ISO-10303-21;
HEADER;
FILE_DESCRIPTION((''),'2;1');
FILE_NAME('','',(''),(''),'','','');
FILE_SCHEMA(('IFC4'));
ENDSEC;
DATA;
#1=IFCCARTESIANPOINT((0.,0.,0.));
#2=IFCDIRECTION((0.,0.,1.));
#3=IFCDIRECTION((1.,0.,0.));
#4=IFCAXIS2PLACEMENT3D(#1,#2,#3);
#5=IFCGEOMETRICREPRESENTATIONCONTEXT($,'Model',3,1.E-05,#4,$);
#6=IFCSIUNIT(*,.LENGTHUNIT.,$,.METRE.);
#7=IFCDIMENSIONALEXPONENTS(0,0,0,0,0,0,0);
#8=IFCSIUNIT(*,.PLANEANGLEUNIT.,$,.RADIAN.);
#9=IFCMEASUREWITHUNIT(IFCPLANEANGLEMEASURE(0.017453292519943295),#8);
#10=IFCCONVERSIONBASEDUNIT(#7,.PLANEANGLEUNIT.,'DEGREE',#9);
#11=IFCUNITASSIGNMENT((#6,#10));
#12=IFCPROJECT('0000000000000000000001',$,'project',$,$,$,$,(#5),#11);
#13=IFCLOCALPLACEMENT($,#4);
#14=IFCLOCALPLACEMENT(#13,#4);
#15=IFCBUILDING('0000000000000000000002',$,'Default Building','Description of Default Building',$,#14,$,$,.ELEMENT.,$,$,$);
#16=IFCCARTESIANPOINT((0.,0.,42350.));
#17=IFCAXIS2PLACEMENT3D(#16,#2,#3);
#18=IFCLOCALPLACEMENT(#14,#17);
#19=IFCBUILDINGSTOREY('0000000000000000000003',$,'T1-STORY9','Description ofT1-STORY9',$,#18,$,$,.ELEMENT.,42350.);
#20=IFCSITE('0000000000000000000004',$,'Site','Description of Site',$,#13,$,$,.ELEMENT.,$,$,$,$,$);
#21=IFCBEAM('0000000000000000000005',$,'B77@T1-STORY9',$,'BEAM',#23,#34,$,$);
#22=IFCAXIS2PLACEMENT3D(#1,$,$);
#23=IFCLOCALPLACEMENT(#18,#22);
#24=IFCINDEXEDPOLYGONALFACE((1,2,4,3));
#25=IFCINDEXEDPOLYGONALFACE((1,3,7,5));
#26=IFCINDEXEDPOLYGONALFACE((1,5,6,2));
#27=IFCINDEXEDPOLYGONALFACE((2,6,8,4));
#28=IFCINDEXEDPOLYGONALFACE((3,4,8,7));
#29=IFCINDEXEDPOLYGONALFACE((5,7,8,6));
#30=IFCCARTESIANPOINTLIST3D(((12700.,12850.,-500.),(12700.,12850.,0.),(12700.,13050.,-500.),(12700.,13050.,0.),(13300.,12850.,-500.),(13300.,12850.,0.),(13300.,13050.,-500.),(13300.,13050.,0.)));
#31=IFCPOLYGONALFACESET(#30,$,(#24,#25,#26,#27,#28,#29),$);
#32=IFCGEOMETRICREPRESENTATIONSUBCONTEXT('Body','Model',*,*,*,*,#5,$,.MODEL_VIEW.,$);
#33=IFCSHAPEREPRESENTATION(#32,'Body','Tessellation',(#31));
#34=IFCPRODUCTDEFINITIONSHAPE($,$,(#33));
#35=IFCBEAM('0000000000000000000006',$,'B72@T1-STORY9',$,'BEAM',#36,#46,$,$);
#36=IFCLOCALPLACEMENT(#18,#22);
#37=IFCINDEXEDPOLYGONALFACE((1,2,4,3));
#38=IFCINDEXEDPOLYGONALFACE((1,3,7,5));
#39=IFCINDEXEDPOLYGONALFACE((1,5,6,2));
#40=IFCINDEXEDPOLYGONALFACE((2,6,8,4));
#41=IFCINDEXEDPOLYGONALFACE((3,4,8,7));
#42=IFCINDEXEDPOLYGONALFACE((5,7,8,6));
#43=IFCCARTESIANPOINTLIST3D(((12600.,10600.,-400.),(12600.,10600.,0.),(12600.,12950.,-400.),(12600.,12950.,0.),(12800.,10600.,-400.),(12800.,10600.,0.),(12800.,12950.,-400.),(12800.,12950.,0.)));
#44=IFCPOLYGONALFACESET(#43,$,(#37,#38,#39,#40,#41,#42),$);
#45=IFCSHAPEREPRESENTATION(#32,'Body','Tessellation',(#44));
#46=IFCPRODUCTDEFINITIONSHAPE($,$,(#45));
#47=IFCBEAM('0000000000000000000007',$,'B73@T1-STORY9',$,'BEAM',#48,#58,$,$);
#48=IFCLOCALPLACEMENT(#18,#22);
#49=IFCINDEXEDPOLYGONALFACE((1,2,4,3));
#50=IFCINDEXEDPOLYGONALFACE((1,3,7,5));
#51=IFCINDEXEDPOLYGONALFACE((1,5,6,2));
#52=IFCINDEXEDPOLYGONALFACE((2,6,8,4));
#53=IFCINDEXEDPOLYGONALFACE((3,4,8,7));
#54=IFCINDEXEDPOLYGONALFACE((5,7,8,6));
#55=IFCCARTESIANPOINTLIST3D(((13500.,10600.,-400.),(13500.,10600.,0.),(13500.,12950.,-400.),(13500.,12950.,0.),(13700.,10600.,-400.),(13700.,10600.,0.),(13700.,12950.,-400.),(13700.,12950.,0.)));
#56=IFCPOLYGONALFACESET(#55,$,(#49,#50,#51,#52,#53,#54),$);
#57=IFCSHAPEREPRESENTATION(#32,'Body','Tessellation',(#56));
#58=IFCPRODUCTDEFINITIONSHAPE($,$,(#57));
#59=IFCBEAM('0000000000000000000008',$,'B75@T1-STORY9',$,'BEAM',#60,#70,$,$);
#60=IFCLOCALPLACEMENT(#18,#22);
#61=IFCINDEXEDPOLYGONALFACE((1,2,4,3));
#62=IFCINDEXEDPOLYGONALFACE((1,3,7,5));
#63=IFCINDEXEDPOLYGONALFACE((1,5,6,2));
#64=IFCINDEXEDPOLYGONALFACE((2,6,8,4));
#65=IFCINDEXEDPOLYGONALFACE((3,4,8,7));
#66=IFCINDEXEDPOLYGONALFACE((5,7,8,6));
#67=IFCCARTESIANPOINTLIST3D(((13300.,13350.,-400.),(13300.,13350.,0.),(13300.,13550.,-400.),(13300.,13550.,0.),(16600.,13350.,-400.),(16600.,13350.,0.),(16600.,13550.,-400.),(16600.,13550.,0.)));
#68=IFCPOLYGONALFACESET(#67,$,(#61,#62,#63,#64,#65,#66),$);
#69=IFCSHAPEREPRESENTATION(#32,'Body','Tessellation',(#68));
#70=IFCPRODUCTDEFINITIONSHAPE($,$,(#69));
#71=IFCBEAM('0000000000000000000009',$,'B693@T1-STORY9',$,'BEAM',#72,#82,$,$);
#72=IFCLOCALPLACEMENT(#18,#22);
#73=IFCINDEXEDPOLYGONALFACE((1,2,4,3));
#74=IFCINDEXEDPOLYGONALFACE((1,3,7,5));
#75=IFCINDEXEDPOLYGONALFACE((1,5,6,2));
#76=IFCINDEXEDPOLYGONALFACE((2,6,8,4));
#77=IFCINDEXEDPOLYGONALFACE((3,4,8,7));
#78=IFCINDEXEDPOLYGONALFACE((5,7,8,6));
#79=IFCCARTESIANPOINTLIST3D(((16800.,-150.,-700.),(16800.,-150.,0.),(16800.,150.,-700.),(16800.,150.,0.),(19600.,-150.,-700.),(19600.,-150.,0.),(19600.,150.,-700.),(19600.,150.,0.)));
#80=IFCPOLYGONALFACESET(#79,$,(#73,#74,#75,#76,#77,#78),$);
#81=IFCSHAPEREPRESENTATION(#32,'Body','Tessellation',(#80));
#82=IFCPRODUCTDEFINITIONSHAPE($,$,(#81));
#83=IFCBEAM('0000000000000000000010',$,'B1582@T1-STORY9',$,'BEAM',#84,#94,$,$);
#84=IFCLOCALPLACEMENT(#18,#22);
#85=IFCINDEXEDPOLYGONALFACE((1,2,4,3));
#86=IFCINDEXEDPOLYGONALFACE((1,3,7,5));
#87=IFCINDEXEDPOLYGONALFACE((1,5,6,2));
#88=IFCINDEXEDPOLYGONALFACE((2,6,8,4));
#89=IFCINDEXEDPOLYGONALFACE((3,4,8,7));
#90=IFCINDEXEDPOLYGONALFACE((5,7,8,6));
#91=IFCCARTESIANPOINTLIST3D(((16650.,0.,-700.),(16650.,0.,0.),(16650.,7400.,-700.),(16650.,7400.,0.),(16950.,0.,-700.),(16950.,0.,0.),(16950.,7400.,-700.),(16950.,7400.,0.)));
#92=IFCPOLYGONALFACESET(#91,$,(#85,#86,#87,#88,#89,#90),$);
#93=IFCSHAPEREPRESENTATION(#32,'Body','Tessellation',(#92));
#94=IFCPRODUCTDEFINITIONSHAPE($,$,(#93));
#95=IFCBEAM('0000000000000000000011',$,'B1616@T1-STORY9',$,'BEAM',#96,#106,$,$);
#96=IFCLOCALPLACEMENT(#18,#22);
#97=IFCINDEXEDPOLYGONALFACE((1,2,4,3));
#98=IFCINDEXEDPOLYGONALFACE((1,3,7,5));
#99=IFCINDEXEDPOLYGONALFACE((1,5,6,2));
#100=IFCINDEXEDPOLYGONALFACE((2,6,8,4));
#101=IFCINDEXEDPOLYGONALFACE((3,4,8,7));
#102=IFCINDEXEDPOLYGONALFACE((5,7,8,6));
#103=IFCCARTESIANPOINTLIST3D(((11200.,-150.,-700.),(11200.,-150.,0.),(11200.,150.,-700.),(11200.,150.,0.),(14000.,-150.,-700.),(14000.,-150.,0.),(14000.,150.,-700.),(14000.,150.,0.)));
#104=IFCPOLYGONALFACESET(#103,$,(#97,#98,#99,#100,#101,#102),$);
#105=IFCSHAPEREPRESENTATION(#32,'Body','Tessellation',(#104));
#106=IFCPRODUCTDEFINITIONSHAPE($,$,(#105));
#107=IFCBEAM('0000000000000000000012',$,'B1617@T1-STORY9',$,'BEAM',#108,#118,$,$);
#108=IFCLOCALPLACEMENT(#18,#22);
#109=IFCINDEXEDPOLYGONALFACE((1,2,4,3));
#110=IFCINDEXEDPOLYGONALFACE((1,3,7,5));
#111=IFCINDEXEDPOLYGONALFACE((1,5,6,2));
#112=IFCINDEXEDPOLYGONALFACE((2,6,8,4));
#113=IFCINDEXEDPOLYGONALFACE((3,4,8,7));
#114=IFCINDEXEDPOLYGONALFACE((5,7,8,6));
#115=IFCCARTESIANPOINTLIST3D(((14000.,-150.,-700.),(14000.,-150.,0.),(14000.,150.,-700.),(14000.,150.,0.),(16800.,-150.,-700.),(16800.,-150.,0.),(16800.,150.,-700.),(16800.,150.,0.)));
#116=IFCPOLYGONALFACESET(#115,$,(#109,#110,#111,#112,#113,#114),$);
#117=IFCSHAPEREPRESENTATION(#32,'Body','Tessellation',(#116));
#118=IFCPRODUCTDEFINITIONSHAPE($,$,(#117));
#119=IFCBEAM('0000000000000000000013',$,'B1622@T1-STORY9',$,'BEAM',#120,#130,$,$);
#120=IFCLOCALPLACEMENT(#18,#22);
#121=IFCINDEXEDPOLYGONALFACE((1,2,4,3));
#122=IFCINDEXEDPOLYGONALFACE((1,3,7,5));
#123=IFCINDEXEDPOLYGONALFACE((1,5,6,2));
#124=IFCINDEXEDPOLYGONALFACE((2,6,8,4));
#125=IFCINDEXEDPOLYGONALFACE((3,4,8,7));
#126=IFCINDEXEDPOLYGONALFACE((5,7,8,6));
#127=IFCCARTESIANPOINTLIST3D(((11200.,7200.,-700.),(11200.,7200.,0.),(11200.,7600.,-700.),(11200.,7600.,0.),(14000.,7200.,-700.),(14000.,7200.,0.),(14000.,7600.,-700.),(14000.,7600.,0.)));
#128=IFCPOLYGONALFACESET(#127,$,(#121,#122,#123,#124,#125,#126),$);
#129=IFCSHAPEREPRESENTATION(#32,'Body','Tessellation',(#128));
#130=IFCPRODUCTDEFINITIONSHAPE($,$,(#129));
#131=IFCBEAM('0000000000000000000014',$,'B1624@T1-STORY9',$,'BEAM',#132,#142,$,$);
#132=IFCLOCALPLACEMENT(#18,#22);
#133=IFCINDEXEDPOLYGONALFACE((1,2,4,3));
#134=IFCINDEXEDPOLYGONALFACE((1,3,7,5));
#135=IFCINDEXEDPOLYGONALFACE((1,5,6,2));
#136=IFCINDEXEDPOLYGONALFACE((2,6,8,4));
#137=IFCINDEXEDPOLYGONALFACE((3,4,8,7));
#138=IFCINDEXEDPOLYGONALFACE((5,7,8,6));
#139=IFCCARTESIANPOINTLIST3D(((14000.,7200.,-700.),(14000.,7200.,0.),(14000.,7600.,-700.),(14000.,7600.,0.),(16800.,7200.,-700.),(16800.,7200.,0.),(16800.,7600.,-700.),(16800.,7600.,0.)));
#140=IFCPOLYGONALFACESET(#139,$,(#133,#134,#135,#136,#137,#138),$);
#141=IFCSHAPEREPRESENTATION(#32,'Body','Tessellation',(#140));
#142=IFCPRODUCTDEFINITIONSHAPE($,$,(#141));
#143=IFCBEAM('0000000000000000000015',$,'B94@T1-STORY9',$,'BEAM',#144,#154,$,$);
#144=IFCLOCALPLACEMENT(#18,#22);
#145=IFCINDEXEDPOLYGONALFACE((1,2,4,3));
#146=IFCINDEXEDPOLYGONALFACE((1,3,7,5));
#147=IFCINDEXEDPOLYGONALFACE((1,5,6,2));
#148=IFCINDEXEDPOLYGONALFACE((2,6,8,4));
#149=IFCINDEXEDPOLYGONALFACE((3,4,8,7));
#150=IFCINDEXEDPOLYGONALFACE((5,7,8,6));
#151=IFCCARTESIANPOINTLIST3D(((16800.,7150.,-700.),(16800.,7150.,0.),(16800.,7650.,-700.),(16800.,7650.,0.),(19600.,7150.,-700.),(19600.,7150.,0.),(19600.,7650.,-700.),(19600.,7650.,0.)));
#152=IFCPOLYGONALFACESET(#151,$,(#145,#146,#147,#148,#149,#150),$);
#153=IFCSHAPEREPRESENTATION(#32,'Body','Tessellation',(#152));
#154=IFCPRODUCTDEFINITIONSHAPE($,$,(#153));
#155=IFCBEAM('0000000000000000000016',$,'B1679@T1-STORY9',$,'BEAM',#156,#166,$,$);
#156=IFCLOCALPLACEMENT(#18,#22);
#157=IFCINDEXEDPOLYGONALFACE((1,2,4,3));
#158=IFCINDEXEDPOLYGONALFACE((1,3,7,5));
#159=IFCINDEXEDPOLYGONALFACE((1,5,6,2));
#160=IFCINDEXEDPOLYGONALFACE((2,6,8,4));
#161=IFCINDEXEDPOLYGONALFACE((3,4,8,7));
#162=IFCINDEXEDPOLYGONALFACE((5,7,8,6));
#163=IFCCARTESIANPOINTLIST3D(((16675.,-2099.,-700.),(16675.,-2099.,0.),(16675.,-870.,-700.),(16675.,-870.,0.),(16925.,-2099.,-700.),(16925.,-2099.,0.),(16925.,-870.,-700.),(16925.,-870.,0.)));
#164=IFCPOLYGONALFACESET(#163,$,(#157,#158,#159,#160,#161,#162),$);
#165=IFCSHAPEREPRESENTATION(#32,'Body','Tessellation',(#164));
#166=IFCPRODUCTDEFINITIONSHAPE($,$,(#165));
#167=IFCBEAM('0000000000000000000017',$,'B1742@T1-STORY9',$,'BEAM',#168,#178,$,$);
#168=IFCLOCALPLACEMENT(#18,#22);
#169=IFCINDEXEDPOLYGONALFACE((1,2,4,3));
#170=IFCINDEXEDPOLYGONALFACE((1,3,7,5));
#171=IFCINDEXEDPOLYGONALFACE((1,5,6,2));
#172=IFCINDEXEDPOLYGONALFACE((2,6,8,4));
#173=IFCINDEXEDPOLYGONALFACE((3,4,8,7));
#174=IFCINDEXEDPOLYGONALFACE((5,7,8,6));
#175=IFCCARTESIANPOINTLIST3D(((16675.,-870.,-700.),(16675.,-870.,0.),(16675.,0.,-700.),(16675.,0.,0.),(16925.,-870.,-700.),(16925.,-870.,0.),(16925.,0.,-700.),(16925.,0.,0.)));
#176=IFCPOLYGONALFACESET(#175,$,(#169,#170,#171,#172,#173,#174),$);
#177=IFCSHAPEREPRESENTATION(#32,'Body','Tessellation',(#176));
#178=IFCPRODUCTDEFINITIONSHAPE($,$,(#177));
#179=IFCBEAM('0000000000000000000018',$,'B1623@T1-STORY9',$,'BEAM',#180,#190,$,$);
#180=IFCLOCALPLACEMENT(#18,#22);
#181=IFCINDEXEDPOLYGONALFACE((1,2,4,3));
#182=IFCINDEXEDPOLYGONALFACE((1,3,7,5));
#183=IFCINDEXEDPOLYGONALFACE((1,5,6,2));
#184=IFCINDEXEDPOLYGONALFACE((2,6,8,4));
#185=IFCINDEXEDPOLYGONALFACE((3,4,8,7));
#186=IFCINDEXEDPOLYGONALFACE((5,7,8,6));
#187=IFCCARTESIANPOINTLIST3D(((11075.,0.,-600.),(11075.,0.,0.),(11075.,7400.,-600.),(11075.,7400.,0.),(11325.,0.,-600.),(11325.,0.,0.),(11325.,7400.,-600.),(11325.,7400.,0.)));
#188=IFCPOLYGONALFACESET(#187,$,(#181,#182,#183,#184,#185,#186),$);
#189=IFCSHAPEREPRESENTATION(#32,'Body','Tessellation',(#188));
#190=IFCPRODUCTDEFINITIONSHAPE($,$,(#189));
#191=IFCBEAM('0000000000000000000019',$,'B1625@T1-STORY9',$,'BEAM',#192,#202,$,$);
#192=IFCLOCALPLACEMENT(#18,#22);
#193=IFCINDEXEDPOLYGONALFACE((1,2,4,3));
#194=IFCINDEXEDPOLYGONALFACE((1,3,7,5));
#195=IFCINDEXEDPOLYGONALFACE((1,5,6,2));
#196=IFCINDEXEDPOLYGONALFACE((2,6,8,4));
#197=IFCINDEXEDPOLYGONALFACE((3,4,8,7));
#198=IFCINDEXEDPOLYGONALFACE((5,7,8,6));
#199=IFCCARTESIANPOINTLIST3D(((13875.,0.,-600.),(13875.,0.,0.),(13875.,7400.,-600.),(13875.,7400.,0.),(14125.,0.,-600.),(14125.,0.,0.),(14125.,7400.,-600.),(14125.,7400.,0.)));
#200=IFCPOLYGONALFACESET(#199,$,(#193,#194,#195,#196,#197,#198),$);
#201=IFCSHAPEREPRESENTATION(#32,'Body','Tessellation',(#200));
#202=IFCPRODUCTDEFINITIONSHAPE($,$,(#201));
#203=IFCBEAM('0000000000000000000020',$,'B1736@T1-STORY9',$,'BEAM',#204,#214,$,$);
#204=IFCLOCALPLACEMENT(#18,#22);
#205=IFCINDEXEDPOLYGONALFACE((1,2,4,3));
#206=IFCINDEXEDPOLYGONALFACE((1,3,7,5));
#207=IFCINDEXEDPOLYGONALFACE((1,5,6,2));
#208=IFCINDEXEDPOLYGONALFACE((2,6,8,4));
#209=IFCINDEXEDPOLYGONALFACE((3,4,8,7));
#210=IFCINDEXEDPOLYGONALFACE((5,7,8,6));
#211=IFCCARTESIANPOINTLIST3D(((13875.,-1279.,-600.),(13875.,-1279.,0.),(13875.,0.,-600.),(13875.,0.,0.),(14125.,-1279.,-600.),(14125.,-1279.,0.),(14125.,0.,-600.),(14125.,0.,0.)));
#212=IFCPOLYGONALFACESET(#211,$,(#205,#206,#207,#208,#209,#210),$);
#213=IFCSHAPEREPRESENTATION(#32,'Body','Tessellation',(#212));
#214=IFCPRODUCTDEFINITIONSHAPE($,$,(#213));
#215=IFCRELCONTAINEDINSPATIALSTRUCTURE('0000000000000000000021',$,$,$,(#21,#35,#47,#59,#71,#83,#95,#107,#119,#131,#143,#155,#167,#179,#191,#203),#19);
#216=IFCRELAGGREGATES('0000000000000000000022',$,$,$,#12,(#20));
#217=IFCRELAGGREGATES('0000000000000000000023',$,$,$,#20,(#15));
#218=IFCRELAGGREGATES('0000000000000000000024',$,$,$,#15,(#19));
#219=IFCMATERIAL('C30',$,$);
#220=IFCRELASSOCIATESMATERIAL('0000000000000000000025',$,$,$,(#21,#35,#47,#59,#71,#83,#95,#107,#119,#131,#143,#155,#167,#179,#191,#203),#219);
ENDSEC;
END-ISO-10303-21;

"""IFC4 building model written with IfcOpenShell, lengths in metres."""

from ifc_helpers import new_model, entity, si_unit, converted_unit, frame, origin_with_axes, place, context, subcontext, project, spatial, rectangle, extrude, material, element, save


model = new_model("IFC4")

# Units and contexts
model_context = context("Model", 3, precision=1e-05, world=origin_with_axes())
body_context = subcontext(model_context, "Body", "Model", "MODEL_VIEW")
ifc_project = project(units=[si_unit("LENGTHUNIT", "METRE"), converted_unit("PLANEANGLEUNIT", "DEGREE", entity("IfcPlaneAngleMeasure", 0.017453292519943295), si_unit("PLANEANGLEUNIT", "RADIAN"), dimensions=[0, 0, 0, 0, 0, 0, 0])], contexts=[model_context])

# Site, building, storey
site_placement = place(None, origin_with_axes())
site = spatial("IfcSite", under=ifc_project, at=site_placement, Name="Site", Description="Description of Site", CompositionType="ELEMENT")
building_placement = place(site_placement, origin_with_axes())
building = spatial("IfcBuilding", under=site, at=building_placement, Name="Default Building", Description="Description of Default Building", CompositionType="ELEMENT")
storey_placement = place(building_placement, frame((0.0, 0.0, 42350.0), z_axis=(0.0, 0.0, 1.0), x_axis=(1.0, 0.0, 0.0)))
storey = spatial("IfcBuildingStorey", under=building, at=storey_placement, Name="T1-STORY9", Description="Description ofT1-STORY9", CompositionType="ELEMENT", Elevation=42350.0)

# Beams
ifc_material_1 = material(Name="C30")
beam_1_placement = place(storey_placement, frame((12700.0, 12950.0, -250.0), z_axis=(1.0, 0.0, 0.0), x_axis=(0.0, 1.0, 0.0)))
element("IfcBeam", 1, at=beam_1_placement, inside=storey, material=ifc_material_1, Name="B77@T1-STORY9", ObjectType="BEAM", context=body_context, shape_type="SweptSolid", body=[
    extrude(rectangle(XDim=200.0, YDim=500.0), origin_with_axes(), (0.0, 0.0, 1.0), 600.0),
])
for number, where, z_axis, x_axis, name in (
    (2, (12700.0, 10600.0, -200.0), (0.0, 1.0, 0.0), (-1.0, 0.0, 0.0), "B72@T1-STORY9"),
    (3, (13600.0, 10600.0, -200.0), (0.0, 1.0, 0.0), (-1.0, 0.0, 0.0), "B73@T1-STORY9"),
):
    element("IfcBeam", number, at=place(storey_placement, frame(where, z_axis=z_axis, x_axis=x_axis)), inside=storey, material=ifc_material_1, Name=name, ObjectType="BEAM", context=body_context, shape_type="SweptSolid", body=[
        extrude(rectangle(XDim=200.0, YDim=400.0), origin_with_axes(), (0.0, 0.0, 1.0), 2350.0),
    ])
beam_2_placement = place(storey_placement, frame((13300.0, 13450.0, -200.0), z_axis=(1.0, 0.0, 0.0), x_axis=(0.0, 1.0, 0.0)))
element("IfcBeam", 4, at=beam_2_placement, inside=storey, material=ifc_material_1, Name="B75@T1-STORY9", ObjectType="BEAM", context=body_context, shape_type="SweptSolid", body=[
    extrude(rectangle(XDim=200.0, YDim=400.0), origin_with_axes(), (0.0, 0.0, 1.0), 3300.0),
])
beam_3_placement = place(storey_placement, frame((16800.0, 0.0, -350.0), z_axis=(1.0, 0.0, 0.0), x_axis=(0.0, 1.0, 0.0)))
element("IfcBeam", 5, at=beam_3_placement, inside=storey, material=ifc_material_1, Name="B693@T1-STORY9", ObjectType="BEAM", context=body_context, shape_type="SweptSolid", body=[
    extrude(rectangle(XDim=300.0, YDim=700.0), origin_with_axes(), (0.0, 0.0, 1.0), 2800.0),
])
beam_4_placement = place(storey_placement, frame((16800.0, 0.0, -350.0), z_axis=(0.0, 1.0, 0.0), x_axis=(-1.0, 0.0, 0.0)))
element("IfcBeam", 6, at=beam_4_placement, inside=storey, material=ifc_material_1, Name="B1582@T1-STORY9", ObjectType="BEAM", context=body_context, shape_type="SweptSolid", body=[
    extrude(rectangle(XDim=300.0, YDim=700.0), origin_with_axes(), (0.0, 0.0, 1.0), 7400.0),
])
for number, where, z_axis, x_axis, name in (
    (7, (11200.0, 0.0, -350.0), (1.0, 0.0, 0.0), (0.0, 1.0, 0.0), "B1616@T1-STORY9"),
    (8, (14000.0, 0.0, -350.0), (1.0, 0.0, 0.0), (0.0, 1.0, 0.0), "B1617@T1-STORY9"),
):
    element("IfcBeam", number, at=place(storey_placement, frame(where, z_axis=z_axis, x_axis=x_axis)), inside=storey, material=ifc_material_1, Name=name, ObjectType="BEAM", context=body_context, shape_type="SweptSolid", body=[
        extrude(rectangle(XDim=300.0, YDim=700.0), origin_with_axes(), (0.0, 0.0, 1.0), 2800.0),
    ])
for number, where, z_axis, x_axis, name in (
    (9, (11200.0, 7400.0, -350.0), (1.0, 0.0, 0.0), (0.0, 1.0, 0.0), "B1622@T1-STORY9"),
    (10, (14000.0, 7400.0, -350.0), (1.0, 0.0, 0.0), (0.0, 1.0, 0.0), "B1624@T1-STORY9"),
):
    element("IfcBeam", number, at=place(storey_placement, frame(where, z_axis=z_axis, x_axis=x_axis)), inside=storey, material=ifc_material_1, Name=name, ObjectType="BEAM", context=body_context, shape_type="SweptSolid", body=[
        extrude(rectangle(XDim=400.0, YDim=700.0), origin_with_axes(), (0.0, 0.0, 1.0), 2800.0),
    ])
beam_5_placement = place(storey_placement, frame((16800.0, 7400.0, -350.0), z_axis=(1.0, 0.0, 0.0), x_axis=(0.0, 1.0, 0.0)))
element("IfcBeam", 11, at=beam_5_placement, inside=storey, material=ifc_material_1, Name="B94@T1-STORY9", ObjectType="BEAM", context=body_context, shape_type="SweptSolid", body=[
    extrude(rectangle(XDim=500.0, YDim=700.0), origin_with_axes(), (0.0, 0.0, 1.0), 2800.0),
])
beam_6_placement = place(storey_placement, frame((16800.0, -2099.0, -350.0), z_axis=(0.0, 1.0, 0.0), x_axis=(-1.0, 0.0, 0.0)))
element("IfcBeam", 12, at=beam_6_placement, inside=storey, material=ifc_material_1, Name="B1679@T1-STORY9", ObjectType="BEAM", context=body_context, shape_type="SweptSolid", body=[
    extrude(rectangle(XDim=250.0, YDim=700.0), origin_with_axes(), (0.0, 0.0, 1.0), 1229.0),
])
beam_7_placement = place(storey_placement, frame((16800.0, -870.0, -350.0), z_axis=(0.0, 1.0, 0.0), x_axis=(-1.0, 0.0, 0.0)))
element("IfcBeam", 13, at=beam_7_placement, inside=storey, material=ifc_material_1, Name="B1742@T1-STORY9", ObjectType="BEAM", context=body_context, shape_type="SweptSolid", body=[
    extrude(rectangle(XDim=250.0, YDim=700.0), origin_with_axes(), (0.0, 0.0, 1.0), 870.0),
])
for number, where, z_axis, x_axis, name in (
    (14, (11200.0, 0.0, -300.0), (0.0, 1.0, 0.0), (-1.0, 0.0, 0.0), "B1623@T1-STORY9"),
    (15, (14000.0, 0.0, -300.0), (0.0, 1.0, 0.0), (-1.0, 0.0, 0.0), "B1625@T1-STORY9"),
):
    element("IfcBeam", number, at=place(storey_placement, frame(where, z_axis=z_axis, x_axis=x_axis)), inside=storey, material=ifc_material_1, Name=name, ObjectType="BEAM", context=body_context, shape_type="SweptSolid", body=[
        extrude(rectangle(XDim=250.0, YDim=600.0), origin_with_axes(), (0.0, 0.0, 1.0), 7400.0),
    ])
beam_8_placement = place(storey_placement, frame((14000.0, -1279.0, -300.0), z_axis=(0.0, 1.0, 0.0), x_axis=(-1.0, 0.0, 0.0)))
element("IfcBeam", 16, at=beam_8_placement, inside=storey, material=ifc_material_1, Name="B1736@T1-STORY9", ObjectType="BEAM", context=body_context, shape_type="SweptSolid", body=[
    extrude(rectangle(XDim=250.0, YDim=600.0), origin_with_axes(), (0.0, 0.0, 1.0), 1279.0),
])

save(model, "model.ifc")
